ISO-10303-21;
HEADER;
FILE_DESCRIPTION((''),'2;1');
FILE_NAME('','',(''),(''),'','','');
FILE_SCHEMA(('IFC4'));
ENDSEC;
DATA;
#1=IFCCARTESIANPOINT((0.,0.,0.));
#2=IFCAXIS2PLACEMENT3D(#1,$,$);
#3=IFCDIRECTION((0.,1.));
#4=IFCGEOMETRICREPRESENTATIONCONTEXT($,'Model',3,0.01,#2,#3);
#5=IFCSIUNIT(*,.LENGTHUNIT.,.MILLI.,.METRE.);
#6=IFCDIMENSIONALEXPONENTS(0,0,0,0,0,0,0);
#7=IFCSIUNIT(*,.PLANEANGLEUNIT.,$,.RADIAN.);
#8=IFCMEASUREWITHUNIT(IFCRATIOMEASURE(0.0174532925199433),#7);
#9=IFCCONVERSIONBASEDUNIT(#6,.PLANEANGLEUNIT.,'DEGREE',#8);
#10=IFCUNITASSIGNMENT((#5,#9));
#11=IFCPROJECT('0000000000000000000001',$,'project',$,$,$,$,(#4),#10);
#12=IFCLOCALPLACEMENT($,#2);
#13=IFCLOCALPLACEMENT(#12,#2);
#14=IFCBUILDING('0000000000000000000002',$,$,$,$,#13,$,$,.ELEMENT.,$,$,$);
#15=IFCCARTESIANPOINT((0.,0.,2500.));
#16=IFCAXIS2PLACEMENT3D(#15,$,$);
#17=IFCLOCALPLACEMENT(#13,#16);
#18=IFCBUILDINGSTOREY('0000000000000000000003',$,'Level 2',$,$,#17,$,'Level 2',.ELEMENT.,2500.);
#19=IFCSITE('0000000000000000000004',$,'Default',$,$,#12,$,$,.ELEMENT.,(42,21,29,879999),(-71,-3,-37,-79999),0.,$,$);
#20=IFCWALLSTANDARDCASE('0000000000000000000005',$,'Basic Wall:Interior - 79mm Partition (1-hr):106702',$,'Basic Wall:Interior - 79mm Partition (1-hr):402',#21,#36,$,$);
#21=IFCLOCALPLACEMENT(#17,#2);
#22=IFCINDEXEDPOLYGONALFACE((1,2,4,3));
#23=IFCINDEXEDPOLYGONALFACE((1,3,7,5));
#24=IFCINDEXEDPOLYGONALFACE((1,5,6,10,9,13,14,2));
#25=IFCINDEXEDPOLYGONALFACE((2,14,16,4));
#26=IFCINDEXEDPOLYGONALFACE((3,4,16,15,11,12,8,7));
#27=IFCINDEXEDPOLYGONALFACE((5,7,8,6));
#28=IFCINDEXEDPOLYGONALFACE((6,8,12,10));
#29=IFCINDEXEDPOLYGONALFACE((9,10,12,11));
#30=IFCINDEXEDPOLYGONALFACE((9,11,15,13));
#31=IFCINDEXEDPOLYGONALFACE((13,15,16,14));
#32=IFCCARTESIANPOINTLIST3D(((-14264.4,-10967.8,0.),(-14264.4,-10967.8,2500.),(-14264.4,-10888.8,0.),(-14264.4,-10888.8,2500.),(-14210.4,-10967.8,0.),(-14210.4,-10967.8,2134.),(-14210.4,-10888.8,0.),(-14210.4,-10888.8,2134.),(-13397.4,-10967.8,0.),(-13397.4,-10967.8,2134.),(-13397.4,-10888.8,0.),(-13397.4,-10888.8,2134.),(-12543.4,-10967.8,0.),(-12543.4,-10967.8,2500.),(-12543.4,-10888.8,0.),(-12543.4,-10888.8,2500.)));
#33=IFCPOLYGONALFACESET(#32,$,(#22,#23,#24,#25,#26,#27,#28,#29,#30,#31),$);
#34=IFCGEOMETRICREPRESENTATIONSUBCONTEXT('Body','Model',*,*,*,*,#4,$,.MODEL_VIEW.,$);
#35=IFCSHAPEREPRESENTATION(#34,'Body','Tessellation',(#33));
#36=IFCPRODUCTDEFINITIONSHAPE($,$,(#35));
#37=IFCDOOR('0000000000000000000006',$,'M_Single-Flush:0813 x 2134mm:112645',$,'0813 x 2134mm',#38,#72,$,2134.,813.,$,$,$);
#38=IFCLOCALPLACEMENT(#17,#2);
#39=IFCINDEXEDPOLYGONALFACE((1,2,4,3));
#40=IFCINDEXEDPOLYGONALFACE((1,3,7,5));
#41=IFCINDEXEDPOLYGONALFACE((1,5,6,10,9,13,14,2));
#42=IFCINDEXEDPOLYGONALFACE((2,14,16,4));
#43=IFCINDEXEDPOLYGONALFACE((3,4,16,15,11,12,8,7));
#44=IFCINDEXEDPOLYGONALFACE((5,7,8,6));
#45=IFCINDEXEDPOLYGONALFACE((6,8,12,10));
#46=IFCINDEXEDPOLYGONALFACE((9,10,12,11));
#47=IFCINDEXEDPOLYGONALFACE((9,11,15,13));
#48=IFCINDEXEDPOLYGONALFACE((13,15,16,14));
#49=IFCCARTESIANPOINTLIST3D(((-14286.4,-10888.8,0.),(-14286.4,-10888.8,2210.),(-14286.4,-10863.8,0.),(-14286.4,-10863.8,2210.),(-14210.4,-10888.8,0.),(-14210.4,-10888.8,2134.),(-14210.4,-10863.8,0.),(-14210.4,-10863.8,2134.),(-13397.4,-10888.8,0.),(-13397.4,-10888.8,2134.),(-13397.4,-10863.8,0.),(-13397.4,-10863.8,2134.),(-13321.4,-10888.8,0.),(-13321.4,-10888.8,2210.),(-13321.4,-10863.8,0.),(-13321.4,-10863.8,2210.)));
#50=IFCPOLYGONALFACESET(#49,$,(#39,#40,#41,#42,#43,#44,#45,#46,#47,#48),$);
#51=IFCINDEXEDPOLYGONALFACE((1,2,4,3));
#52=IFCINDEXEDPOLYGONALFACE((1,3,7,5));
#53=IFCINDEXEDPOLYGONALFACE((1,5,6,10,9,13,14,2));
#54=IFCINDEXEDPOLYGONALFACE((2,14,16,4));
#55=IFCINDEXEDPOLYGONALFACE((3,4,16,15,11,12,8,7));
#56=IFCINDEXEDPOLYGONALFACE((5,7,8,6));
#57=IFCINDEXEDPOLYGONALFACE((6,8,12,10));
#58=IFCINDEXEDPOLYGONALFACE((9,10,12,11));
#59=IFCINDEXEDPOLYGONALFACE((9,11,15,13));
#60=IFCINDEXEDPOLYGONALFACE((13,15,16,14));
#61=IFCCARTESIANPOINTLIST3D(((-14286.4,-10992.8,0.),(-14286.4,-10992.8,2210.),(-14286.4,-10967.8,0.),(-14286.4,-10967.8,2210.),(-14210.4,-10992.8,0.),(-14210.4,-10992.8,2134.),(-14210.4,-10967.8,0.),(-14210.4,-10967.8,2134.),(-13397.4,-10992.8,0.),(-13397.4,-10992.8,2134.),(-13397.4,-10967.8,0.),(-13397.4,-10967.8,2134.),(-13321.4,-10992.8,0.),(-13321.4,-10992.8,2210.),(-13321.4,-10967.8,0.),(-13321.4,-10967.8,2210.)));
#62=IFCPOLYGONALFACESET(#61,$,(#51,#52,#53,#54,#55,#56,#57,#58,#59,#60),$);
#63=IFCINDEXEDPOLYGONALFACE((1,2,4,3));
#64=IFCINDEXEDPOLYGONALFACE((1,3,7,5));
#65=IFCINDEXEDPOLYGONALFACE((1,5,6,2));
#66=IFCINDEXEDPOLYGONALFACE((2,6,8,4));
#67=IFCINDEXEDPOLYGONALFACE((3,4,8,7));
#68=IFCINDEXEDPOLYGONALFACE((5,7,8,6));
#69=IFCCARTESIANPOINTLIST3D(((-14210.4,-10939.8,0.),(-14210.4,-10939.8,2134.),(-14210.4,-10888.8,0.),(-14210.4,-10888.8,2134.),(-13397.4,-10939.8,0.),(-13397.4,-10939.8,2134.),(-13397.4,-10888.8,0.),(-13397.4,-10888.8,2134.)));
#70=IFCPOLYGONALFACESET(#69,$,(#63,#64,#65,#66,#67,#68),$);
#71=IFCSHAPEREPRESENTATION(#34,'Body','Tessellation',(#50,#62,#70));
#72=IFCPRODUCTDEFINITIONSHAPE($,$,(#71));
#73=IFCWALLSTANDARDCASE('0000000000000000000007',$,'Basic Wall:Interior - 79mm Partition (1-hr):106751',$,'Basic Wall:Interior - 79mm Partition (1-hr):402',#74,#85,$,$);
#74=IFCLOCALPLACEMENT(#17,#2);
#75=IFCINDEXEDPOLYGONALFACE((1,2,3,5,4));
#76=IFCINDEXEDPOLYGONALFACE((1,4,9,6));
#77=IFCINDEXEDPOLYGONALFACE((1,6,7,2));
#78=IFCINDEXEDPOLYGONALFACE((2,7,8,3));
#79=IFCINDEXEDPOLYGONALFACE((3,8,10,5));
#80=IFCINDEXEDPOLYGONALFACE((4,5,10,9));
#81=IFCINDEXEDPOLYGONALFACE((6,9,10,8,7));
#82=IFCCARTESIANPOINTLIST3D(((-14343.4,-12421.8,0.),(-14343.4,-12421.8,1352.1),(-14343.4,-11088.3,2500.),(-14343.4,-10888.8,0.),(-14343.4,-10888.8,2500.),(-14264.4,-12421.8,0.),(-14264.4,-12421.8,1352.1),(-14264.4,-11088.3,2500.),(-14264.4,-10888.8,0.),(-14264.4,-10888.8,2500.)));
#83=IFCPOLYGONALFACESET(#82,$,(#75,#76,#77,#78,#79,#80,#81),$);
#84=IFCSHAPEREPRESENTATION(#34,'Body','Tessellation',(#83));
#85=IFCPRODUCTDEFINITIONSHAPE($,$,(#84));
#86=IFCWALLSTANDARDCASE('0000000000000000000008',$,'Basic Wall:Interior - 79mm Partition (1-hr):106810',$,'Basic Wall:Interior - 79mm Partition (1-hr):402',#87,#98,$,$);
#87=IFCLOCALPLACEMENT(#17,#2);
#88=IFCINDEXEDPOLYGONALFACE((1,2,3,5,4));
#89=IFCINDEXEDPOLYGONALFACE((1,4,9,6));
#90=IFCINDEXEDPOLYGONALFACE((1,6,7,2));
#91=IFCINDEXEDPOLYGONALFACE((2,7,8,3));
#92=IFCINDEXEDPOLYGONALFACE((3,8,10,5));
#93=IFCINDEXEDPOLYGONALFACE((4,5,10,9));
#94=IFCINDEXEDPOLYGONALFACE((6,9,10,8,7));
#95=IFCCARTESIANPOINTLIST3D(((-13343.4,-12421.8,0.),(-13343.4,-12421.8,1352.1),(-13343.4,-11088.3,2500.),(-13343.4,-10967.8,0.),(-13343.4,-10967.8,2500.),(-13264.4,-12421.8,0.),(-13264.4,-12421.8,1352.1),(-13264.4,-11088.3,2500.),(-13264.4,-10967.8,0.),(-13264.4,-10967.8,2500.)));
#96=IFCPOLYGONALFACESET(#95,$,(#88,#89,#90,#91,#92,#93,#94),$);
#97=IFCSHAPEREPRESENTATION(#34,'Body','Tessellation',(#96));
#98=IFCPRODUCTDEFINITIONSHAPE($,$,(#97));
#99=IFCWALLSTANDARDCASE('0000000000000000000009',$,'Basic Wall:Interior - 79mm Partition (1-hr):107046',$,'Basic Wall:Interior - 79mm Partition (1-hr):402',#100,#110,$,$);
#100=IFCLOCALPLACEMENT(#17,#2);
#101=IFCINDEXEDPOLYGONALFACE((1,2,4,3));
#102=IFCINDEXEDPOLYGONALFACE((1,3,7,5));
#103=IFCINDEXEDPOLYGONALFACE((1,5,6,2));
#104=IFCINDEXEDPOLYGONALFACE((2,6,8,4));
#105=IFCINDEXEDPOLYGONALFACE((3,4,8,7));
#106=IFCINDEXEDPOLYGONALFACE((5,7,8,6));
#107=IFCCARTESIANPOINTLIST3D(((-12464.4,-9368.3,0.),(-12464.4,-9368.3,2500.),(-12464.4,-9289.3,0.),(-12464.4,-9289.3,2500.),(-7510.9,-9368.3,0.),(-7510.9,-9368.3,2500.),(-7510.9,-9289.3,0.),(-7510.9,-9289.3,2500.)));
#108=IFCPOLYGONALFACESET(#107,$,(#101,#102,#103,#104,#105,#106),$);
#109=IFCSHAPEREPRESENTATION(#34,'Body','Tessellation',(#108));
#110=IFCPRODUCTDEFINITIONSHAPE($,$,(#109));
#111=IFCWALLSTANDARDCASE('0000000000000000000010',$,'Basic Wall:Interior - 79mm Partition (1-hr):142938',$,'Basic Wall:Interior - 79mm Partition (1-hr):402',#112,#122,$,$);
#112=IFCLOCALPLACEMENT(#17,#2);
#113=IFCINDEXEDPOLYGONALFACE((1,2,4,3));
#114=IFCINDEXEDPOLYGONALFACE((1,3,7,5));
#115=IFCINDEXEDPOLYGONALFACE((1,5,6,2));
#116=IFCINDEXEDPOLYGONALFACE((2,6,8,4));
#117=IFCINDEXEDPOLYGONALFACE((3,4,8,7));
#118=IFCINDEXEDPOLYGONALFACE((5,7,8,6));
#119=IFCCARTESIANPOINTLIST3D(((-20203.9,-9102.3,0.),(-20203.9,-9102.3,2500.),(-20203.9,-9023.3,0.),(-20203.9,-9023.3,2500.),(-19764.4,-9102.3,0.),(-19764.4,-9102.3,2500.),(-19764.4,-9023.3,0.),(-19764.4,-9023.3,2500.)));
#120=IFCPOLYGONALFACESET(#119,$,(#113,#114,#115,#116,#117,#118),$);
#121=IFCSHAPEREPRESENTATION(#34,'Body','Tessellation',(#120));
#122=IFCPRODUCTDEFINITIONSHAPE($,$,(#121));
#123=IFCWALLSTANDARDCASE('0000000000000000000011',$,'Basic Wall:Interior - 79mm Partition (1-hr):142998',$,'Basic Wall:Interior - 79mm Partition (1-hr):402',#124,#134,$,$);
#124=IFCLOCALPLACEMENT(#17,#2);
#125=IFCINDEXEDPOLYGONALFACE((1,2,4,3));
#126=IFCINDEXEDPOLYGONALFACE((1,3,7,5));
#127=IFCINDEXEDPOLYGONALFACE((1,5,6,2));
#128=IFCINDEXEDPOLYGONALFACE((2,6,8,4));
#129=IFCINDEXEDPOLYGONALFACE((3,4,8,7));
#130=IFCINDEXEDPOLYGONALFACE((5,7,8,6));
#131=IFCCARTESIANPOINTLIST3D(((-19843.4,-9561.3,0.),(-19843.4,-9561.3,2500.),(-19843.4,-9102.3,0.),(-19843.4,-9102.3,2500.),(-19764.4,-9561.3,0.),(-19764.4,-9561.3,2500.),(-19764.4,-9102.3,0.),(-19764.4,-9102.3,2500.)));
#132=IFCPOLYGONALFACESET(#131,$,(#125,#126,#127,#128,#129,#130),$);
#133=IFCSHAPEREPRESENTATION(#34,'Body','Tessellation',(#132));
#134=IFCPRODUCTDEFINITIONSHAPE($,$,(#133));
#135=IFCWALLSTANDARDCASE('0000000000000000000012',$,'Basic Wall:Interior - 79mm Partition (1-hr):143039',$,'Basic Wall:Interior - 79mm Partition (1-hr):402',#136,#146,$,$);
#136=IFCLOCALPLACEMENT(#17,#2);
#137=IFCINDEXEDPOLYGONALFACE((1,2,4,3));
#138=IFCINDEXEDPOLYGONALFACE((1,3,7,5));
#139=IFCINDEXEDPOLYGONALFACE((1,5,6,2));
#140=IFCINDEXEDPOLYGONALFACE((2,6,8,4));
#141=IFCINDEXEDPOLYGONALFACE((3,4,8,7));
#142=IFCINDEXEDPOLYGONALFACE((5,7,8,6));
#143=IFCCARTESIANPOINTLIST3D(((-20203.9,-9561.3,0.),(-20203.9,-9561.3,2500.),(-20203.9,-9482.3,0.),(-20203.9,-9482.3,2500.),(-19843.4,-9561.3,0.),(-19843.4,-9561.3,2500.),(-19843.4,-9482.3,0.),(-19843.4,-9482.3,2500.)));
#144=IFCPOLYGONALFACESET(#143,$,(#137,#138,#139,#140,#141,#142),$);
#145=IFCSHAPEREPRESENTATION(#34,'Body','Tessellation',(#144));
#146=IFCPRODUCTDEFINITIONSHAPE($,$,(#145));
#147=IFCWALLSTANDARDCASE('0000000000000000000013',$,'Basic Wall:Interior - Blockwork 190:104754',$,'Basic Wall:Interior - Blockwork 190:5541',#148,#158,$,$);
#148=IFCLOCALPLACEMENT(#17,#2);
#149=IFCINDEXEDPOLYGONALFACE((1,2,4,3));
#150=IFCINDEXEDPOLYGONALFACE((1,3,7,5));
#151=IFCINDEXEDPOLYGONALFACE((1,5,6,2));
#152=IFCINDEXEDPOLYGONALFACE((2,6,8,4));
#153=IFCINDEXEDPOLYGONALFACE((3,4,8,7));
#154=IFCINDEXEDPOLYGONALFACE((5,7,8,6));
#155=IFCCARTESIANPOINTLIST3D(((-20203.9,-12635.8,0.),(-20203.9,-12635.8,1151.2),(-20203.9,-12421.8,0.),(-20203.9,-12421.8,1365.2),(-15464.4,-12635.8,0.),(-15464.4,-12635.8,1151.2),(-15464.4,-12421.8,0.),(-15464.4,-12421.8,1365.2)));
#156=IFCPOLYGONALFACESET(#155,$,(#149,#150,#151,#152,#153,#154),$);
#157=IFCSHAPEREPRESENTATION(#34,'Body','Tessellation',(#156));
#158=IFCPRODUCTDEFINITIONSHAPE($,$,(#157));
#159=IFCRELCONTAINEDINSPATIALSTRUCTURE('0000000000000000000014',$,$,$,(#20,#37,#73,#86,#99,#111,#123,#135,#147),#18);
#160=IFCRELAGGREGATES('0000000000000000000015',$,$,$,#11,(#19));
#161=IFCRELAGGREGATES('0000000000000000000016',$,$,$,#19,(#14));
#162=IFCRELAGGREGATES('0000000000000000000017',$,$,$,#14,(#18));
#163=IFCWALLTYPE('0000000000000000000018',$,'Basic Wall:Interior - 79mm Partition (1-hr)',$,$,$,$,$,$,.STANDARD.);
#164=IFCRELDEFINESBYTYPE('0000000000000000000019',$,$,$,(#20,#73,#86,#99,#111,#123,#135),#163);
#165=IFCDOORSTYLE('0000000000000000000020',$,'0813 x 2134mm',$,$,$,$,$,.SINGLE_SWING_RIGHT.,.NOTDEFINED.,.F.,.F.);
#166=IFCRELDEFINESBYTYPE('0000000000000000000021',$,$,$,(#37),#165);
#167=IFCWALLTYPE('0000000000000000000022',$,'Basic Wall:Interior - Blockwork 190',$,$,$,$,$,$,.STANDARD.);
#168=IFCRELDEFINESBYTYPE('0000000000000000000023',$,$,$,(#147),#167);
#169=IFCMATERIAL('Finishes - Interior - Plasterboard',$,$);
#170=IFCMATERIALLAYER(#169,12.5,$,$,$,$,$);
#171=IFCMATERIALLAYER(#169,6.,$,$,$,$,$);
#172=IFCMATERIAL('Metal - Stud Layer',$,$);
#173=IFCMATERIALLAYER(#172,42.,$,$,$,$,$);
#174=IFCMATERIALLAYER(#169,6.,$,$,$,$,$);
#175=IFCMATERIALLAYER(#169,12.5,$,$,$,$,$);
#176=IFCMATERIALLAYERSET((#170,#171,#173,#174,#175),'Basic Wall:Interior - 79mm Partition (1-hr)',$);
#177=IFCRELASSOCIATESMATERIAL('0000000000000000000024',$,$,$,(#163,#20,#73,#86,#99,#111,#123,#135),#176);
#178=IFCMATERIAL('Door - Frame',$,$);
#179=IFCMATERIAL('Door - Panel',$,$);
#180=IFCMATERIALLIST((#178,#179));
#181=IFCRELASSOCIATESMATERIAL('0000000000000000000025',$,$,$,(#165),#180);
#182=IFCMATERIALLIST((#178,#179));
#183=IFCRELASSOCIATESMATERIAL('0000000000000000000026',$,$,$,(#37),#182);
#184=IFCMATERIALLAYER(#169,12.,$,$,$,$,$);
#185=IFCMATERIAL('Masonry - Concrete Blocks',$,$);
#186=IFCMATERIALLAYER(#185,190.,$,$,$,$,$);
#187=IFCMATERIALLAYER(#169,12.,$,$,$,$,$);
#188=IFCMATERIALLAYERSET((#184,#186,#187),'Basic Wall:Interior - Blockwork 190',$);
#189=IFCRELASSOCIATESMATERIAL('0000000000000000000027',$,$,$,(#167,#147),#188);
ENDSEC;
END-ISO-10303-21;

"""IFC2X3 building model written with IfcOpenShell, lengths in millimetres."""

from ifc_helpers import new_model, entity, si_unit, converted_unit, direction, frame, frame_2d, origin, origin_2d_with_axis, place, context, subcontext, project, spatial, polyline, rectangle, outline, extrude, clip, halfspace, bounded_halfspace, source, transform, mapped, material, material_list, layer, layer_set, layer_usage, type_object, type_shapes, element, fill, save


model = new_model("IFC2X3")

# Units and contexts
model_context = context("Model", 3, precision=0.01, world=origin(), true_north=direction((0.0, 1.0)))
body_context = subcontext(model_context, "Body", "Model", "MODEL_VIEW")
ifc_project = project(units=[si_unit("LENGTHUNIT", "METRE", prefix="MILLI"), converted_unit("PLANEANGLEUNIT", "DEGREE", entity("IfcRatioMeasure", 0.0174532925199433), si_unit("PLANEANGLEUNIT", "RADIAN"), dimensions=[0, 0, 0, 0, 0, 0, 0])], contexts=[model_context])

# Site, building, storey
site_placement = place(None, origin())
site = spatial("IfcSite", under=ifc_project, at=site_placement, Name="Default", CompositionType="ELEMENT", RefLatitude=(42, 21, 29, 879999), RefLongitude=(-71, -3, -37, -79999), RefElevation=0.0)
building_placement = place(site_placement, origin())
building = spatial("IfcBuilding", under=site, at=building_placement, CompositionType="ELEMENT")
storey_placement = place(building_placement, frame((0.0, 0.0, 2500.0)))
storey = spatial("IfcBuildingStorey", under=building, at=storey_placement, Name="Level 2", LongName="Level 2", CompositionType="ELEMENT", Elevation=2500.0)

# Shared definitions
ifc_material_1 = material(Name="Finishes - Interior - Plasterboard")
ifc_layer_1 = layer(ifc_material_1, 12.5)
ifc_layer_2 = layer(ifc_material_1, 6.0)
ifc_material_2 = material(Name="Metal - Stud Layer")
ifc_layer_3 = layer(ifc_material_2, 42.0)
ifc_layer_4 = layer(ifc_material_1, 6.0)
ifc_layer_5 = layer(ifc_material_1, 12.5)
ifc_layer_set_1 = layer_set([ifc_layer_1, ifc_layer_2, ifc_layer_3, ifc_layer_4, ifc_layer_5], Name="Basic Wall:Interior - 79mm Partition (1-hr)")
wall_type_1 = type_object("IfcWallType", Name="Basic Wall:Interior - 79mm Partition (1-hr)", PredefinedType="STANDARD", material=ifc_layer_set_1)

# Shared definitions
ifc_material_3 = material(Name="Door - Frame")
ifc_material_4 = material(Name="Door - Panel")
ifc_material_list_1 = material_list([ifc_material_3, ifc_material_4])
door_style_1 = type_object("IfcDoorStyle", Name="0813 x 2134mm", ConstructionType="NOTDEFINED", OperationType="SINGLE_SWING_RIGHT", ParameterTakesPrecedence=False, Sizeable=False, material=ifc_material_list_1)
shared_shape_1 = source(origin(), body_context, "Body", "SweptSolid", [
    extrude(outline(polyline([(-482.5, -1124.0), (482.5, -1124.0), (482.5, 1086.0), (406.5, 1086.0), (406.5, -1048.0), (-406.5, -1048.0), (-406.5, 1086.0), (-482.5, 1086.0), (-482.5, -1124.0)])), frame((406.5, 79.0, 1086.0), z_axis=(0.0, 1.0, 0.0), x_axis=(1.0, 0.0, 0.0)), (0.0, 0.0, 1.0), 25.0),
    extrude(outline(polyline([(-1124.0, -482.5), (1086.0, -482.5), (1086.0, -406.5), (-1048.0, -406.5), (-1048.0, 406.5), (1086.0, 406.5), (1086.0, 482.5), (-1124.0, 482.5), (-1124.0, -482.5)])), frame((406.5, -25.0, 1086.0), z_axis=(0.0, 1.0, 0.0), x_axis=(0.0, 0.0, -1.0)), (0.0, 0.0, 1.0), 25.0),
    extrude(rectangle(XDim=51.0, YDim=813.0, at=origin_2d_with_axis()), frame((406.5, 53.5, 0.0), z_axis=(0.0, 0.0, 1.0), x_axis=(0.0, 1.0, 0.0)), (0.0, 0.0, 1.0), 2134.0),
])
type_shapes(door_style_1, [shared_shape_1])

# Wall, opening, door
ifc_layer_usage_1 = layer_usage(ifc_layer_set_1, "AXIS2", "NEGATIVE", 39.5)
wall_1_placement = place(storey_placement, frame((-12543.4, -10928.3, 0.0), z_axis=(0.0, 0.0, 1.0), x_axis=(-1.0, 0.0, 0.0)))
wall_1 = element("IfcWallStandardCase", 1, at=wall_1_placement, inside=storey, type_object=wall_type_1, material=ifc_layer_usage_1, Name="Basic Wall:Interior - 79mm Partition (1-hr):106702", ObjectType="Basic Wall:Interior - 79mm Partition (1-hr):402", context=body_context, shape_type="SweptSolid", body=[
    extrude(rectangle(XDim=1721.0, YDim=79.0, at=frame_2d((860.5, 0.0), x_axis=(-1.0, 0.0))), origin(), (0.0, 0.0, 1.0), 2500.0),
])
opening_1_placement = place(wall_1_placement, frame((1667.0, 39.5, 0.0)))
opening_1 = element("IfcOpeningElement", 2, at=opening_1_placement, cuts=wall_1, ObjectType="Opening", context=body_context, shape_type="SweptSolid", body=[
    extrude(rectangle(XDim=813.0, YDim=2134.0, at=frame_2d((1067.0, 406.5), x_axis=(0.0, 1.0))), frame((0.0, 0.0, 0.0), z_axis=(0.0, -1.0, 0.0), x_axis=(0.0, 0.0, 1.0)), (0.0, 0.0, 1.0), 79.0),
])
ifc_material_list_2 = material_list([ifc_material_3, ifc_material_4])
door_1_placement = place(opening_1_placement, frame((0.0, 0.0, 0.0), z_axis=(0.0, 0.0, 1.0), x_axis=(-1.0, 0.0, 0.0)))
door_1 = element("IfcDoor", 3, at=door_1_placement, inside=storey, type_object=door_style_1, material=ifc_material_list_2, Name="M_Single-Flush:0813 x 2134mm:112645", ObjectType="0813 x 2134mm", OverallHeight=2134.0, OverallWidth=813.0, context=body_context, shape_type="MappedRepresentation", body=[
    mapped(shared_shape_1, transform((0.0, 0.0, 0.0), scale=1.0)),
])
fill(opening_1, door_1)

# Walls
ifc_layer_usage_2 = layer_usage(ifc_layer_set_1, "AXIS2", "POSITIVE", -39.5)
wall_2_placement = place(storey_placement, frame((-14303.9, -10888.8, 0.0), z_axis=(0.0, 0.0, 1.0), x_axis=(0.0, -1.0, 0.0)))
element("IfcWallStandardCase", 4, at=wall_2_placement, inside=storey, type_object=wall_type_1, material=ifc_layer_usage_2, Name="Basic Wall:Interior - 79mm Partition (1-hr):106751", ObjectType="Basic Wall:Interior - 79mm Partition (1-hr):402", context=body_context, shape_type="Clipping", body=[
    clip(extrude(rectangle(XDim=1533.0, YDim=79.0, at=frame_2d((766.5, 0.0), x_axis=(-1.0, 0.0))), origin(), (0.0, 0.0, 1.0), 2500.0), halfspace(frame((199.5, -39.5, 2500.0), z_axis=(0.652393, 0.0, 0.757881), x_axis=(0.0, 1.0, 0.0)), False)),
])
ifc_layer_usage_3 = layer_usage(ifc_layer_set_1, "AXIS2", "NEGATIVE", 39.5)
wall_3_placement = place(storey_placement, frame((-13303.9, -10967.8, 0.0), z_axis=(0.0, 0.0, 1.0), x_axis=(0.0, -1.0, 0.0)))
element("IfcWallStandardCase", 5, at=wall_3_placement, inside=storey, type_object=wall_type_1, material=ifc_layer_usage_3, Name="Basic Wall:Interior - 79mm Partition (1-hr):106810", ObjectType="Basic Wall:Interior - 79mm Partition (1-hr):402", context=body_context, shape_type="Clipping", body=[
    clip(extrude(rectangle(XDim=1454.0, YDim=79.0, at=frame_2d((727.0, 0.0), x_axis=(-1.0, 0.0))), origin(), (0.0, 0.0, 1.0), 2500.0), halfspace(frame((120.5, -39.5, 2500.0), z_axis=(0.652393, 0.0, 0.757881), x_axis=(0.0, 1.0, 0.0)), False)),
])
ifc_layer_usage_4 = layer_usage(ifc_layer_set_1, "AXIS2", "NEGATIVE", 39.5)
wall_4_placement = place(storey_placement, frame((-12464.4, -9328.8, 0.0)))
element("IfcWallStandardCase", 6, at=wall_4_placement, inside=storey, type_object=wall_type_1, material=ifc_layer_usage_4, Name="Basic Wall:Interior - 79mm Partition (1-hr):107046", ObjectType="Basic Wall:Interior - 79mm Partition (1-hr):402", context=body_context, shape_type="SweptSolid", body=[
    extrude(rectangle(XDim=4953.5, YDim=79.0, at=frame_2d((2476.8, 0.0), x_axis=(-1.0, 0.0))), origin(), (0.0, 0.0, 1.0), 2500.0),
])
ifc_layer_usage_5 = layer_usage(ifc_layer_set_1, "AXIS2", "NEGATIVE", 39.5)
wall_5_placement = place(storey_placement, frame((-20203.9, -9062.8, 0.0)))
element("IfcWallStandardCase", 7, at=wall_5_placement, inside=storey, type_object=wall_type_1, material=ifc_layer_usage_5, Name="Basic Wall:Interior - 79mm Partition (1-hr):142938", ObjectType="Basic Wall:Interior - 79mm Partition (1-hr):402", context=body_context, shape_type="SweptSolid", body=[
    extrude(rectangle(XDim=439.5, YDim=79.0, at=frame_2d((219.7, 0.0), x_axis=(-1.0, 0.0))), origin(), (0.0, 0.0, 1.0), 2500.0),
])
ifc_layer_usage_6 = layer_usage(ifc_layer_set_1, "AXIS2", "NEGATIVE", 39.5)
wall_6_placement = place(storey_placement, frame((-19803.9, -9102.3, 0.0), z_axis=(0.0, 0.0, 1.0), x_axis=(0.0, -1.0, 0.0)))
element("IfcWallStandardCase", 8, at=wall_6_placement, inside=storey, type_object=wall_type_1, material=ifc_layer_usage_6, Name="Basic Wall:Interior - 79mm Partition (1-hr):142998", ObjectType="Basic Wall:Interior - 79mm Partition (1-hr):402", context=body_context, shape_type="SweptSolid", body=[
    extrude(rectangle(XDim=459.0, YDim=79.0, at=frame_2d((229.5, 0.0), x_axis=(-1.0, 0.0))), origin(), (0.0, 0.0, 1.0), 2500.0),
])
ifc_layer_usage_7 = layer_usage(ifc_layer_set_1, "AXIS2", "NEGATIVE", 39.5)
wall_7_placement = place(storey_placement, frame((-19843.4, -9521.8, 0.0), z_axis=(0.0, 0.0, 1.0), x_axis=(-1.0, 0.0, 0.0)))
element("IfcWallStandardCase", 9, at=wall_7_placement, inside=storey, type_object=wall_type_1, material=ifc_layer_usage_7, Name="Basic Wall:Interior - 79mm Partition (1-hr):143039", ObjectType="Basic Wall:Interior - 79mm Partition (1-hr):402", context=body_context, shape_type="SweptSolid", body=[
    extrude(rectangle(XDim=360.5, YDim=79.0, at=frame_2d((180.2, 0.0), x_axis=(-1.0, 0.0))), origin(), (0.0, 0.0, 1.0), 2500.0),
])
ifc_layer_6 = layer(ifc_material_1, 12.0)
ifc_material_5 = material(Name="Masonry - Concrete Blocks")
ifc_layer_7 = layer(ifc_material_5, 190.0)
ifc_layer_8 = layer(ifc_material_1, 12.0)
ifc_layer_set_2 = layer_set([ifc_layer_6, ifc_layer_7, ifc_layer_8], Name="Basic Wall:Interior - Blockwork 190")
ifc_layer_usage_8 = layer_usage(ifc_layer_set_2, "AXIS2", "NEGATIVE", 107.0)
wall_type_2 = type_object("IfcWallType", Name="Basic Wall:Interior - Blockwork 190", PredefinedType="STANDARD", material=ifc_layer_set_2)
wall_8_placement = place(storey_placement, frame((-20203.9, -12528.8, 0.0)))
element("IfcWallStandardCase", 10, at=wall_8_placement, inside=storey, type_object=wall_type_2, material=ifc_layer_usage_8, Name="Basic Wall:Interior - Blockwork 190:104754", ObjectType="Basic Wall:Interior - Blockwork 190:5541", context=body_context, shape_type="Clipping", body=[
    clip(extrude(rectangle(XDim=4739.5, YDim=214.0, at=frame_2d((2369.8, 0.0), x_axis=(-1.0, 0.0))), origin(), (0.0, 0.0, 1.0), 1365.2), bounded_halfspace(frame((0.0, -107.0, 1151.2), z_axis=(0.0, 0.707107, -0.707107), x_axis=(-1.0, 0.0, 0.0)), True, frame((0.0, -107.0, 1151.2)), polyline([(0.0, 0.0), (4739.5, 0.0), (4739.5, 214.0), (0.0, 214.0), (0.0, 0.0)]))),
])

save(model, "model.ifc")
